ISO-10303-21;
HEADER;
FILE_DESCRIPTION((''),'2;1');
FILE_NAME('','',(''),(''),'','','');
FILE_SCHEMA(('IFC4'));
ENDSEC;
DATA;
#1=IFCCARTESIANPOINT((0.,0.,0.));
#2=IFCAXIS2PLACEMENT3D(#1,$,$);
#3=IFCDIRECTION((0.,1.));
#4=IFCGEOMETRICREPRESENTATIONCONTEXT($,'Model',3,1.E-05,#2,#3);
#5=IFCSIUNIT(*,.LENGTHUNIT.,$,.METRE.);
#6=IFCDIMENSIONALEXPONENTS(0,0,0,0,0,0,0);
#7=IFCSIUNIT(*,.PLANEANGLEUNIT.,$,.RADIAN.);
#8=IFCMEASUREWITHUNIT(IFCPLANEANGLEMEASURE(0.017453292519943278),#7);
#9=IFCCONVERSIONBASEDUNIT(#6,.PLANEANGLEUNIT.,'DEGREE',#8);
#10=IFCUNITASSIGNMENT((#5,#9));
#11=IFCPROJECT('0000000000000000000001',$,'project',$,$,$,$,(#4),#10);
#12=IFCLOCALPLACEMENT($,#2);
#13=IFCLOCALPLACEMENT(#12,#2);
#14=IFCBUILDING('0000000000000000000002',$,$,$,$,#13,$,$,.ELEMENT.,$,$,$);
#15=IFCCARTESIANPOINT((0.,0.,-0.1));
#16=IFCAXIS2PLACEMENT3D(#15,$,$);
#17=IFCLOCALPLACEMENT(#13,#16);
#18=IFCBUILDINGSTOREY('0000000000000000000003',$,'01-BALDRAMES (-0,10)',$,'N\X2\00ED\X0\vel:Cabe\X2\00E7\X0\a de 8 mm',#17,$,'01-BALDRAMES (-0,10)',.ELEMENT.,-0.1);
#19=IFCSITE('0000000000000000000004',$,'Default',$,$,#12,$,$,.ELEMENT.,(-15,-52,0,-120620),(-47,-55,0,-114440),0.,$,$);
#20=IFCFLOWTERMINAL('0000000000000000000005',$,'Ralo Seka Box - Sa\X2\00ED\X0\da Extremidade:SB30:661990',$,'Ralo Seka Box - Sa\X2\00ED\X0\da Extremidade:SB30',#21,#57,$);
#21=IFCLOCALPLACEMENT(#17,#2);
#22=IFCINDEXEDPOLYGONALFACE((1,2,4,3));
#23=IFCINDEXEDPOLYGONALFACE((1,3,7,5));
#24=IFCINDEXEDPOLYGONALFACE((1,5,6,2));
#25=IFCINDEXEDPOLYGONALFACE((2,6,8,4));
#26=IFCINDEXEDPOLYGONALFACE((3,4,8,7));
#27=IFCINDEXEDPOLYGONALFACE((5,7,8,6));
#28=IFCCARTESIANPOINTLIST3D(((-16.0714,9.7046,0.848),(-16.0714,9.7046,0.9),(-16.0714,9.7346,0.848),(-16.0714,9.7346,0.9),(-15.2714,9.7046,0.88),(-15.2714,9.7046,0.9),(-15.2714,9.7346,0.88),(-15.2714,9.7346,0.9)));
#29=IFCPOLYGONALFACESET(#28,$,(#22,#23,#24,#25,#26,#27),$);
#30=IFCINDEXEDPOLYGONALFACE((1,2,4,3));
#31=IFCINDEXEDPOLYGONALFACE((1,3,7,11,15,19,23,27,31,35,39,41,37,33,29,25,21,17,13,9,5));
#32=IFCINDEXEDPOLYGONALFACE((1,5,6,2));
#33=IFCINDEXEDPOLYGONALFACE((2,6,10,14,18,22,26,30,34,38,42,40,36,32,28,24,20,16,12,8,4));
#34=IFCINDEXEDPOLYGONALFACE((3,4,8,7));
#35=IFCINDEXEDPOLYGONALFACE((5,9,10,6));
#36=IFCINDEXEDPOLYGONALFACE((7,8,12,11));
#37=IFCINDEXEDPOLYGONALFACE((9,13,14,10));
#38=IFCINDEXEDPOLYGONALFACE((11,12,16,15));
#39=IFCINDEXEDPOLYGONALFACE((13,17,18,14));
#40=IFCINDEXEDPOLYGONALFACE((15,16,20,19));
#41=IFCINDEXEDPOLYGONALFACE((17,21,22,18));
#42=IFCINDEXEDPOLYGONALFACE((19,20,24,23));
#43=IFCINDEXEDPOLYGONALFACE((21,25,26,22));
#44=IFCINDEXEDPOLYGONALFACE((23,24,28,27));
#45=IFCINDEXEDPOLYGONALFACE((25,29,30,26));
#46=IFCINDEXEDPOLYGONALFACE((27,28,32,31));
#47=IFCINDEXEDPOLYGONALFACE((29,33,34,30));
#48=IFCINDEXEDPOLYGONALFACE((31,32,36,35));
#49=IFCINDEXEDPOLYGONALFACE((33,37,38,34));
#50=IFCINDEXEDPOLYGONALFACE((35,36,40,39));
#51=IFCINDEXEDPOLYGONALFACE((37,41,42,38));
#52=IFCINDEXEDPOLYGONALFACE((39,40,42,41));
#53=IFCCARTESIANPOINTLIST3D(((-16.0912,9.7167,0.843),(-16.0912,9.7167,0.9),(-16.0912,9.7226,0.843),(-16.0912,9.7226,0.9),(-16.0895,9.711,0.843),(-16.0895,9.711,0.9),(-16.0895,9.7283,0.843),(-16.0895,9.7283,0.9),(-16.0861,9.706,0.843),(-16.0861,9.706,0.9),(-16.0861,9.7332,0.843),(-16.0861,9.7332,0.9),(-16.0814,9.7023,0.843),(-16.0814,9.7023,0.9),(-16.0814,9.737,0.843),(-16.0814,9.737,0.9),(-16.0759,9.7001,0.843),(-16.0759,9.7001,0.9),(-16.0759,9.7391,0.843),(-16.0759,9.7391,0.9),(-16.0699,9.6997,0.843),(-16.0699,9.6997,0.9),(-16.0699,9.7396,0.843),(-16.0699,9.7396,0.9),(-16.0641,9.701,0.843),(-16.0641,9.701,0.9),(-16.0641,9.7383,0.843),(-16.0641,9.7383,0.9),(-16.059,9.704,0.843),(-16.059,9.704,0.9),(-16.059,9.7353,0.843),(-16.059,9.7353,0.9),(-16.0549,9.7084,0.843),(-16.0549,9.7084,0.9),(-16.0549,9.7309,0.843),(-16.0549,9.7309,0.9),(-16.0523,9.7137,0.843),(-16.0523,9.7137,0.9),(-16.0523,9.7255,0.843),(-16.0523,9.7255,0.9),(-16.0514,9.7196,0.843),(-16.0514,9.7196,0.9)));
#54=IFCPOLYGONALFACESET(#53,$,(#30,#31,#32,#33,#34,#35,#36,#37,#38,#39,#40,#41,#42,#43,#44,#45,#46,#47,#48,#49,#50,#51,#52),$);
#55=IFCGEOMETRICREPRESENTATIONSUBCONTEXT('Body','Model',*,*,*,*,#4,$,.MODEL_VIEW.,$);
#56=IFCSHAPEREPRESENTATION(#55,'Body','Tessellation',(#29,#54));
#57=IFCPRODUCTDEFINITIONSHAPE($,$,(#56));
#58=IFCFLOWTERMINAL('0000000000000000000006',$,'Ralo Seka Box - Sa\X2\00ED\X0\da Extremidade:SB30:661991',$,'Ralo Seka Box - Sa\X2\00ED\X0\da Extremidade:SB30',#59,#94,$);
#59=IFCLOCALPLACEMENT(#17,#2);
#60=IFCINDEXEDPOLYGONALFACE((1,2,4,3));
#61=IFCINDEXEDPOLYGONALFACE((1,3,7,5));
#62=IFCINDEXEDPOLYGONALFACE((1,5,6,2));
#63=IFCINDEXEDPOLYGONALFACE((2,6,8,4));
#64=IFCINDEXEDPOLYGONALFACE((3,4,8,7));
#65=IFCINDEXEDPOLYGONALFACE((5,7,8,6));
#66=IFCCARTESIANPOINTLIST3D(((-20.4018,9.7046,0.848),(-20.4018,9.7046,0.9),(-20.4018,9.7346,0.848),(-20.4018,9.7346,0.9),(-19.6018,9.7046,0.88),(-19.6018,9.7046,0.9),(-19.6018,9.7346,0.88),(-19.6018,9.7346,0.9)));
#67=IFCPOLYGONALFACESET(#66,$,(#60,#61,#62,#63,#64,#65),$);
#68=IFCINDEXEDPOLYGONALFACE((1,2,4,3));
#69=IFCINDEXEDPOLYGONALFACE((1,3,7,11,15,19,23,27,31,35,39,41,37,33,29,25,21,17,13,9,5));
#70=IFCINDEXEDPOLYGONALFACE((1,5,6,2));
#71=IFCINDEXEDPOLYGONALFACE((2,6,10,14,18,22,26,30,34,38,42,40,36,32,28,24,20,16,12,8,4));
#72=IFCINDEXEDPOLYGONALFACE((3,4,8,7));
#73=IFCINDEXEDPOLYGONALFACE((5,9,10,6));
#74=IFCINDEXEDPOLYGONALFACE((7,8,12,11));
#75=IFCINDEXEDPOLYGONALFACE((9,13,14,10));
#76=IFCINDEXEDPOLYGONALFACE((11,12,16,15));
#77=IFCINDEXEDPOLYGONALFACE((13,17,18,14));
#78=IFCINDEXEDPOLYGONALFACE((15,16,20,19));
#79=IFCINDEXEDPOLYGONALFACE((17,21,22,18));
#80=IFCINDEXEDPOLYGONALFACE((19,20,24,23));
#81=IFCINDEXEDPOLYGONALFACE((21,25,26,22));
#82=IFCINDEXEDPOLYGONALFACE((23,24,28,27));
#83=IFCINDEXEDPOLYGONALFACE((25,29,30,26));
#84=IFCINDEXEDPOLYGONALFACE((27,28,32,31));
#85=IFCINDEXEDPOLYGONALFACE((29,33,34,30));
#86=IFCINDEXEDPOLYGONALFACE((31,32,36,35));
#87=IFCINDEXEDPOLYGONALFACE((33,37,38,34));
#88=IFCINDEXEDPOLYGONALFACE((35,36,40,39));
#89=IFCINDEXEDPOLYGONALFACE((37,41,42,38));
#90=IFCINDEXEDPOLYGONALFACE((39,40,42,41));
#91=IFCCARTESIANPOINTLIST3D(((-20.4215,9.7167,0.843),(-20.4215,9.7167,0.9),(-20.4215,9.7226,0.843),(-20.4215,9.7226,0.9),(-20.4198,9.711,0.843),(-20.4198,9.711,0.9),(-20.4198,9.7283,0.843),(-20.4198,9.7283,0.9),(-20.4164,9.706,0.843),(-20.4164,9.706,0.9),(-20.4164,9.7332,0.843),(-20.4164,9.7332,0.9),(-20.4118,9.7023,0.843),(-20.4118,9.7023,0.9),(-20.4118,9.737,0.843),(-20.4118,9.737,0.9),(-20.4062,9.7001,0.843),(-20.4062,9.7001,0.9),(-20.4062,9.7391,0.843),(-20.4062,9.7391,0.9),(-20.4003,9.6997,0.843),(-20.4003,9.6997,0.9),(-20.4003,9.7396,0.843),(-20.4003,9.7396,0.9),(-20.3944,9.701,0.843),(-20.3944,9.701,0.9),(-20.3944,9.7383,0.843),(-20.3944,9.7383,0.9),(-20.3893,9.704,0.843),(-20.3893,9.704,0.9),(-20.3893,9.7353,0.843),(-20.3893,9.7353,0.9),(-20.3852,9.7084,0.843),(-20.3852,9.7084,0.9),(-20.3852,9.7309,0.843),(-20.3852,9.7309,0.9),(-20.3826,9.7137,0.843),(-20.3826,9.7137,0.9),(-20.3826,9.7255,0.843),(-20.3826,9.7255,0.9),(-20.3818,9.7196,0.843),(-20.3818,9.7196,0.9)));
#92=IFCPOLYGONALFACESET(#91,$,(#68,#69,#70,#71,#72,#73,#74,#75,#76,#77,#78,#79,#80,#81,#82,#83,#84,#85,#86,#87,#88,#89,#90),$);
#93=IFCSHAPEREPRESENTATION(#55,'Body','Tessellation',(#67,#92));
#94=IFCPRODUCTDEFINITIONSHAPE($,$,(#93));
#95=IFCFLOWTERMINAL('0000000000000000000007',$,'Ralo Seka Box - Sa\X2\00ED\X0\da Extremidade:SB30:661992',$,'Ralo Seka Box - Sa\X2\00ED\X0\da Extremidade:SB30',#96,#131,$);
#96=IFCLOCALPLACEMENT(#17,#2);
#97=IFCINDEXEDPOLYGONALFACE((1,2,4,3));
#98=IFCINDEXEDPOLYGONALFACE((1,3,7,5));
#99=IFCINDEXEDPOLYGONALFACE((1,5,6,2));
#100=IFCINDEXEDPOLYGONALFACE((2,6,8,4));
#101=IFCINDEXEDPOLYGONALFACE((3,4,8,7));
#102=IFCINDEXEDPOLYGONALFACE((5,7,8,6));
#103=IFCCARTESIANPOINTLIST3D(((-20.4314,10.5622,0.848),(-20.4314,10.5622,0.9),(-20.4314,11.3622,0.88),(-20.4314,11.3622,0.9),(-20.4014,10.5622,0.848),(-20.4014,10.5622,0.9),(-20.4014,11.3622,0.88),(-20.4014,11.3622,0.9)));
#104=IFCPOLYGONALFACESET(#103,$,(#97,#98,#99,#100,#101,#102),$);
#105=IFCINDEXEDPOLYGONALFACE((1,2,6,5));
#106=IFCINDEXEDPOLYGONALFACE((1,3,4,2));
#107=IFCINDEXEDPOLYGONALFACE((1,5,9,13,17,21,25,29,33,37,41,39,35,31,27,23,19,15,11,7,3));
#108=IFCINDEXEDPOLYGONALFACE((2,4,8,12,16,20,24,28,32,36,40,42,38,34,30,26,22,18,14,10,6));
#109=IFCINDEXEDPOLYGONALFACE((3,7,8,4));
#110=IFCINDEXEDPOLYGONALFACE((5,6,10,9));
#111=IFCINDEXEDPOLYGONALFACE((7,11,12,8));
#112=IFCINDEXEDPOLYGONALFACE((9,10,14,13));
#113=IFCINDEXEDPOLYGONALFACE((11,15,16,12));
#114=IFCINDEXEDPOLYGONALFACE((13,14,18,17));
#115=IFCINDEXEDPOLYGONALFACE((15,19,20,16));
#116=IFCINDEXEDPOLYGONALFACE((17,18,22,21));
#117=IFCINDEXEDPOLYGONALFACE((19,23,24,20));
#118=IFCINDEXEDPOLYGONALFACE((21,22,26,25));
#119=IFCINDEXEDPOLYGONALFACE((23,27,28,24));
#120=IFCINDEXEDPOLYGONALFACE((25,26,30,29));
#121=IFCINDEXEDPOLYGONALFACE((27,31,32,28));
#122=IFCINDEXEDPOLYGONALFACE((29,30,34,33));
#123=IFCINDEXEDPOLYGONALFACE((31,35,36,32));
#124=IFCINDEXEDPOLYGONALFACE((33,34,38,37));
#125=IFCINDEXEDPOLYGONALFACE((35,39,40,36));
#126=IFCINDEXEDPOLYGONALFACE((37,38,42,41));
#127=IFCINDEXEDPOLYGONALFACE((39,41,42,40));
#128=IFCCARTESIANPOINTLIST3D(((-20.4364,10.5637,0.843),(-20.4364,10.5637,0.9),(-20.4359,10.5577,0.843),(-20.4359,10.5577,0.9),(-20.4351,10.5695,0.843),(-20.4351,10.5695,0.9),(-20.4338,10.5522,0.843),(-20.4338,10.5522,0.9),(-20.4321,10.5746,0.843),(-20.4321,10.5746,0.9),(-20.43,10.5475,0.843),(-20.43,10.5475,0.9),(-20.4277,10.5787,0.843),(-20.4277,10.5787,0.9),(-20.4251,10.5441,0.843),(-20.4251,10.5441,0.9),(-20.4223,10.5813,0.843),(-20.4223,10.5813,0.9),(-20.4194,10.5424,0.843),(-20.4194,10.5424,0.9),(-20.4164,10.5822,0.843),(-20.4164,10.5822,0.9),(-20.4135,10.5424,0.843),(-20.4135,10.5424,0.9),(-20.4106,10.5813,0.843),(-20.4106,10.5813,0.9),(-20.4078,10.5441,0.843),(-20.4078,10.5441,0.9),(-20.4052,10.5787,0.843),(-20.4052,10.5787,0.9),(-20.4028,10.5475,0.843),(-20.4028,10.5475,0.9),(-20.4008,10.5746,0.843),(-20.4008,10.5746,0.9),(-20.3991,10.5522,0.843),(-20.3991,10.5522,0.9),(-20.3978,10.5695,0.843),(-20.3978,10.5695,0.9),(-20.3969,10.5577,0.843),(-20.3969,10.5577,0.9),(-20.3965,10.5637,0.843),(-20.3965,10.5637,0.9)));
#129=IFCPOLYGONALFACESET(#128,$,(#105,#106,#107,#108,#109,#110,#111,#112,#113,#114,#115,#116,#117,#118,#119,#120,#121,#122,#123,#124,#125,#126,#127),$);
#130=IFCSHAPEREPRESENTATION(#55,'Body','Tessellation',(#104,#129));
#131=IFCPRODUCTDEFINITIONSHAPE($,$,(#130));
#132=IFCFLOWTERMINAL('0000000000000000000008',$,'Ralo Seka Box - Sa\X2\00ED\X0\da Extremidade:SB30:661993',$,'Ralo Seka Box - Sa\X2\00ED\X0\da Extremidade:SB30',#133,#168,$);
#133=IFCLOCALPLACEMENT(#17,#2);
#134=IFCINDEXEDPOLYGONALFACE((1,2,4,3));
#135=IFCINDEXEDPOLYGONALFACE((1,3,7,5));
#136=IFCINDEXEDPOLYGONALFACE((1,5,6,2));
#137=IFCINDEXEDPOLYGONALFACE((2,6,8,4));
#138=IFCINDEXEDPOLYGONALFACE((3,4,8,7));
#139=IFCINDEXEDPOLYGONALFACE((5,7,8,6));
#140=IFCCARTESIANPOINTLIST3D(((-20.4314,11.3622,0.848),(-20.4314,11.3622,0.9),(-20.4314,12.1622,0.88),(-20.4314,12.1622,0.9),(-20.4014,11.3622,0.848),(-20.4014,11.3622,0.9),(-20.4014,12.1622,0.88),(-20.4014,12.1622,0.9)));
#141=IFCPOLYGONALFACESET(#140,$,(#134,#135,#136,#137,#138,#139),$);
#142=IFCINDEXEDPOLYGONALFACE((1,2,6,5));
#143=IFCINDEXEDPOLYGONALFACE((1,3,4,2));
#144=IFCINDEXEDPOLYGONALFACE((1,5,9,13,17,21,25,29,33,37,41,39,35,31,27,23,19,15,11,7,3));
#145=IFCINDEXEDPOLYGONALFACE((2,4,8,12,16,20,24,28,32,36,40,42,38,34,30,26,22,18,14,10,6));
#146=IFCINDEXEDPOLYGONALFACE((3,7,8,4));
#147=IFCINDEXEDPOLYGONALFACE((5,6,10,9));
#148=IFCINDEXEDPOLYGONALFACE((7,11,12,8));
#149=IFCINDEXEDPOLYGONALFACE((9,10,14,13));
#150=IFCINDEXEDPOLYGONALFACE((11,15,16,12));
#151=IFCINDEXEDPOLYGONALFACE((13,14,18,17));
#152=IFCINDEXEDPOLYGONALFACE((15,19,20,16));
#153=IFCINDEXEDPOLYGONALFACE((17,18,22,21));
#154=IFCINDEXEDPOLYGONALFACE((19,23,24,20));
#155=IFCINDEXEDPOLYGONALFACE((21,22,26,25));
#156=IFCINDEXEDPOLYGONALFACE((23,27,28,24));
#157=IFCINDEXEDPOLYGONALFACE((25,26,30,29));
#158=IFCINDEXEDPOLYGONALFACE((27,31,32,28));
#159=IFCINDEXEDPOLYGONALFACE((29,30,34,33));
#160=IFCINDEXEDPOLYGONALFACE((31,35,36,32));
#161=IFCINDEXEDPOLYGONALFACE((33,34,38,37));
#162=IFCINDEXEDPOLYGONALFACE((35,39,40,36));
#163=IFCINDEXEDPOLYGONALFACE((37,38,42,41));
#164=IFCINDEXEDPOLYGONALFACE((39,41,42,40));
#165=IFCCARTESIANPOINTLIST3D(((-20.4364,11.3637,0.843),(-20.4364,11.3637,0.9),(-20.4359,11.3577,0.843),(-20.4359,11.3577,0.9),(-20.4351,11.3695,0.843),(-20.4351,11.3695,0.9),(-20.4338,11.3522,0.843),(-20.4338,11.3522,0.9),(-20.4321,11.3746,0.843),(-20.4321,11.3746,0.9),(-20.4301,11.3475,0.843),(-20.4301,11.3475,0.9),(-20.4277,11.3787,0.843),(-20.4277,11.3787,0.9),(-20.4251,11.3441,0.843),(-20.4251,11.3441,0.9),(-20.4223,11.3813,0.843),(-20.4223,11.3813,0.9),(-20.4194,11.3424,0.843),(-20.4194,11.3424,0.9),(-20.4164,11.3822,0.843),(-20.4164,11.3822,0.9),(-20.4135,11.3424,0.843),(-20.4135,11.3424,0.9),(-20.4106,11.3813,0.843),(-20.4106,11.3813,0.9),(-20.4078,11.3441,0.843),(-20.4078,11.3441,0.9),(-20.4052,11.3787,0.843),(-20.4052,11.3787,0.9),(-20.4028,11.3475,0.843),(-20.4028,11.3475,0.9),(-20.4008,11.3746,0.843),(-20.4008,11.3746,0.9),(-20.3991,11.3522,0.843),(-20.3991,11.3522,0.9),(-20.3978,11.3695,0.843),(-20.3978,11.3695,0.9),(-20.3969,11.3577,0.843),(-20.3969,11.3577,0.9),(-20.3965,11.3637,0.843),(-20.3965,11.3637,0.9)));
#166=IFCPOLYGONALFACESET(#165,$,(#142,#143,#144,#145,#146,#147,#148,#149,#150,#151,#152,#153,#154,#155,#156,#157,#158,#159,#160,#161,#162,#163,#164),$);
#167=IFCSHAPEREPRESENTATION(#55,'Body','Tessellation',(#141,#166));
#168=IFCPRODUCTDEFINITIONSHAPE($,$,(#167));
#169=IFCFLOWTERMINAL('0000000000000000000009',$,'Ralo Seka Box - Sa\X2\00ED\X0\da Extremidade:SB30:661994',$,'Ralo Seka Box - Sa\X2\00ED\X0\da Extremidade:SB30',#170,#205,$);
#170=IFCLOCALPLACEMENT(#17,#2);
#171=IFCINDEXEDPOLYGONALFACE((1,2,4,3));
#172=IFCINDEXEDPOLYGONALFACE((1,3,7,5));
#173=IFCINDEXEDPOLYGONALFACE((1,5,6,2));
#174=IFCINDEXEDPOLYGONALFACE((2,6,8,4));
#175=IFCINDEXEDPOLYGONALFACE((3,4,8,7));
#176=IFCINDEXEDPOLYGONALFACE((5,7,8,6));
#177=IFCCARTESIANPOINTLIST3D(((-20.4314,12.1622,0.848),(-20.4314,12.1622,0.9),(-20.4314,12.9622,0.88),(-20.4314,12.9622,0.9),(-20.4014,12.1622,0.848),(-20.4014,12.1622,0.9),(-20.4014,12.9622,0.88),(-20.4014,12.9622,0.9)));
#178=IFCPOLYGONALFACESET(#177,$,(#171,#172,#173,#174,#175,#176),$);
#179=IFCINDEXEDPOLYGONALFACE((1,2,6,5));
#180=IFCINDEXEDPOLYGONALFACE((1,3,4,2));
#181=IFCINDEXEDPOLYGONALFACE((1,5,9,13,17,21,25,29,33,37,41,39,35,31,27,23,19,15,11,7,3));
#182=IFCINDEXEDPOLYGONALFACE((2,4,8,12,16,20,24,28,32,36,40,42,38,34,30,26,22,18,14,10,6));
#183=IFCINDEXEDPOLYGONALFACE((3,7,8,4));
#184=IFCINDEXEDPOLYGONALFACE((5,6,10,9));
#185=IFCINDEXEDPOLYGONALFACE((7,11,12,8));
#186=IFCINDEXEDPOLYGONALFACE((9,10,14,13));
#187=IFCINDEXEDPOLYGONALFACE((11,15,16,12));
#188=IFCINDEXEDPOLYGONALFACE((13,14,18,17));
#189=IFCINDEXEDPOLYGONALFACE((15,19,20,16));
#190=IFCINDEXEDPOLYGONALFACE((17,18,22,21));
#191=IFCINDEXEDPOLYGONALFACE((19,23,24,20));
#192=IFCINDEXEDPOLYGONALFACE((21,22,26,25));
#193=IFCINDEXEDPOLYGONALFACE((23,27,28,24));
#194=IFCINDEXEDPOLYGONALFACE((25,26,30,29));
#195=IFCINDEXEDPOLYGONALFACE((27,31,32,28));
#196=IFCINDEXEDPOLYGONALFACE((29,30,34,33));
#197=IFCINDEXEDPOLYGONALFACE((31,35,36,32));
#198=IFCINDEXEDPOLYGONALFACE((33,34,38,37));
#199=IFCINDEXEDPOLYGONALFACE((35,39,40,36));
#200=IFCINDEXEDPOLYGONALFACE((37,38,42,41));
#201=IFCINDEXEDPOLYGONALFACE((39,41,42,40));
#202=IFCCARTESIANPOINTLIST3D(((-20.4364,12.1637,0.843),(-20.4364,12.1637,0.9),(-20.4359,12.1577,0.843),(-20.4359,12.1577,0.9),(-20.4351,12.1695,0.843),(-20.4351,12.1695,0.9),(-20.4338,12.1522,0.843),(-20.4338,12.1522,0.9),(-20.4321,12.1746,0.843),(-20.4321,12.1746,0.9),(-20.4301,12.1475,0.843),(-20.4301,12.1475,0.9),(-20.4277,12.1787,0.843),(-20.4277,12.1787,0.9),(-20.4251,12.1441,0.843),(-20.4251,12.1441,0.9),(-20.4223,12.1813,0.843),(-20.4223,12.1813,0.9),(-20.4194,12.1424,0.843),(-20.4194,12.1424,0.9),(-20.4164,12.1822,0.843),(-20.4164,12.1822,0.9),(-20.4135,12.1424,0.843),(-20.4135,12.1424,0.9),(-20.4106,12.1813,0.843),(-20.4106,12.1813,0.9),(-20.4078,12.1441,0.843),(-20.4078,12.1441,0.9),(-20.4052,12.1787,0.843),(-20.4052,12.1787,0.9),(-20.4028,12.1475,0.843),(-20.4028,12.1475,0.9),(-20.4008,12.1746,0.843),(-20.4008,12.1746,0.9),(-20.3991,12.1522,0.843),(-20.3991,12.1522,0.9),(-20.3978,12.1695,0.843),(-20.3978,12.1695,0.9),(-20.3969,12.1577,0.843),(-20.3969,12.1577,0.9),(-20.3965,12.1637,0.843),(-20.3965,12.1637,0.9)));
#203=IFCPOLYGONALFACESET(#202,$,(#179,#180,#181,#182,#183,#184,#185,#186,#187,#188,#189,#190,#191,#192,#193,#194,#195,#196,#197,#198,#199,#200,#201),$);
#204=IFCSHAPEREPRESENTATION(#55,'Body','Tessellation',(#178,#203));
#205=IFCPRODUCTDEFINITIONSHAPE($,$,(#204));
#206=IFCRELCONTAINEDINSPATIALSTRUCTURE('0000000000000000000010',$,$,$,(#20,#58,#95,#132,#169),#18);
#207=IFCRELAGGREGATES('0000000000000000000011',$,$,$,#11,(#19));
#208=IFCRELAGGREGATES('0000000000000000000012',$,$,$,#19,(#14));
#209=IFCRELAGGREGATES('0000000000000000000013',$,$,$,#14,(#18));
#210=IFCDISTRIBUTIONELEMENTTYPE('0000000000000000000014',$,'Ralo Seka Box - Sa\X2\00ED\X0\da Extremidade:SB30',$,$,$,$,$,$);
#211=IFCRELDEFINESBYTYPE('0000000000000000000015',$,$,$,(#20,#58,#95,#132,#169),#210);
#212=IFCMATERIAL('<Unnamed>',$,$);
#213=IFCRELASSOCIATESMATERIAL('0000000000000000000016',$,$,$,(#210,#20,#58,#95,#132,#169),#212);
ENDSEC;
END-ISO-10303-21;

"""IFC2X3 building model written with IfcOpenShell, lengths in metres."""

from ifc_helpers import new_model, entity, si_unit, converted_unit, direction, frame, frame_2d, origin, place, context, subcontext, project, spatial, polyline, circle, outline, extrude, source, transform, mapped, material, type_object, type_shapes, element, save


model = new_model("IFC2X3")

# Units and contexts
model_context = context("Model", 3, precision=1e-05, world=origin(), true_north=direction((0.0, 1.0)))
body_context = subcontext(model_context, "Body", "Model", "MODEL_VIEW")
ifc_project = project(units=[si_unit("LENGTHUNIT", "METRE"), converted_unit("PLANEANGLEUNIT", "DEGREE", entity("IfcPlaneAngleMeasure", 0.017453292519943278), si_unit("PLANEANGLEUNIT", "RADIAN"), dimensions=[0, 0, 0, 0, 0, 0, 0])], contexts=[model_context])

# Site, building, storey
site_placement = place(None, origin())
site = spatial("IfcSite", under=ifc_project, at=site_placement, Name="Default", CompositionType="ELEMENT", RefLatitude=(-15, -52, 0, -120620), RefLongitude=(-47, -55, 0, -114440), RefElevation=0.0)
building_placement = place(site_placement, origin())
building = spatial("IfcBuilding", under=site, at=building_placement, CompositionType="ELEMENT")
storey_placement = place(building_placement, frame((0.0, 0.0, -0.1)))
storey = spatial("IfcBuildingStorey", under=building, at=storey_placement, Name="01-BALDRAMES (-0,10)", ObjectType="Nível:Cabeça de 8 mm", LongName="01-BALDRAMES (-0,10)", CompositionType="ELEMENT", Elevation=-0.1)

# Shared definitions
ifc_material = material(Name="<Unnamed>")

# Flow terminals
distribution_element_type_1 = type_object("IfcDistributionElementType", Name="Ralo Seka Box - Saída Extremidade:SB30", material=ifc_material)
shared_shape_1 = source(origin(), body_context, "Body", "SweptSolid", [
    extrude(outline(polyline([(-0.3996, -0.018), (0.401, -0.018), (0.399, 0.034), (-0.4004, 0.002), (-0.3996, -0.018)])), frame((0.4, -0.015, -0.018), z_axis=(0.0, 1.0, 0.0), x_axis=(-0.999201, 0.0, -0.039968)), (0.0, 0.0, 1.0), 0.03),
    extrude(circle(Radius=0.02, at=frame_2d((0.0, 0.0), x_axis=(1.0, 0.0))), frame((0.0, 0.0, -0.057)), (0.0, 0.0, 1.0), 0.057),
])
type_shapes(distribution_element_type_1, [shared_shape_1])
for number, where, name in (
    (1, (-16.0714, 9.7196, 0.9), "Ralo Seka Box - Saída Extremidade:SB30:661990"),
    (2, (-20.4018, 9.7196, 0.9), "Ralo Seka Box - Saída Extremidade:SB30:661991"),
):
    element("IfcFlowTerminal", number, at=place(storey_placement, frame(where)), inside=storey, type_object=distribution_element_type_1, material=ifc_material, Name=name, ObjectType="Ralo Seka Box - Saída Extremidade:SB30", context=body_context, shape_type="MappedRepresentation", body=[
        mapped(shared_shape_1, transform((0.0, 0.0, 0.0), scale=1.0)),
    ])
for number, where, z_axis, x_axis, name in (
    (3, (-20.4164, 10.5622, 0.9), (0.0, 0.0, 1.0), (-0.000001, 1.0, 0.0), "Ralo Seka Box - Saída Extremidade:SB30:661992"),
    (4, (-20.4164, 11.3622, 0.9), (0.0, 0.0, 1.0), (-0.000001, 1.0, 0.0), "Ralo Seka Box - Saída Extremidade:SB30:661993"),
    (5, (-20.4164, 12.1622, 0.9), (0.0, 0.0, 1.0), (-0.000001, 1.0, 0.0), "Ralo Seka Box - Saída Extremidade:SB30:661994"),
):
    element("IfcFlowTerminal", number, at=place(storey_placement, frame(where, z_axis=z_axis, x_axis=x_axis)), inside=storey, type_object=distribution_element_type_1, material=ifc_material, Name=name, ObjectType="Ralo Seka Box - Saída Extremidade:SB30", context=body_context, shape_type="MappedRepresentation", body=[
        mapped(shared_shape_1, transform((0.0, 0.0, 0.0), scale=1.0)),
    ])

save(model, "model.ifc")
